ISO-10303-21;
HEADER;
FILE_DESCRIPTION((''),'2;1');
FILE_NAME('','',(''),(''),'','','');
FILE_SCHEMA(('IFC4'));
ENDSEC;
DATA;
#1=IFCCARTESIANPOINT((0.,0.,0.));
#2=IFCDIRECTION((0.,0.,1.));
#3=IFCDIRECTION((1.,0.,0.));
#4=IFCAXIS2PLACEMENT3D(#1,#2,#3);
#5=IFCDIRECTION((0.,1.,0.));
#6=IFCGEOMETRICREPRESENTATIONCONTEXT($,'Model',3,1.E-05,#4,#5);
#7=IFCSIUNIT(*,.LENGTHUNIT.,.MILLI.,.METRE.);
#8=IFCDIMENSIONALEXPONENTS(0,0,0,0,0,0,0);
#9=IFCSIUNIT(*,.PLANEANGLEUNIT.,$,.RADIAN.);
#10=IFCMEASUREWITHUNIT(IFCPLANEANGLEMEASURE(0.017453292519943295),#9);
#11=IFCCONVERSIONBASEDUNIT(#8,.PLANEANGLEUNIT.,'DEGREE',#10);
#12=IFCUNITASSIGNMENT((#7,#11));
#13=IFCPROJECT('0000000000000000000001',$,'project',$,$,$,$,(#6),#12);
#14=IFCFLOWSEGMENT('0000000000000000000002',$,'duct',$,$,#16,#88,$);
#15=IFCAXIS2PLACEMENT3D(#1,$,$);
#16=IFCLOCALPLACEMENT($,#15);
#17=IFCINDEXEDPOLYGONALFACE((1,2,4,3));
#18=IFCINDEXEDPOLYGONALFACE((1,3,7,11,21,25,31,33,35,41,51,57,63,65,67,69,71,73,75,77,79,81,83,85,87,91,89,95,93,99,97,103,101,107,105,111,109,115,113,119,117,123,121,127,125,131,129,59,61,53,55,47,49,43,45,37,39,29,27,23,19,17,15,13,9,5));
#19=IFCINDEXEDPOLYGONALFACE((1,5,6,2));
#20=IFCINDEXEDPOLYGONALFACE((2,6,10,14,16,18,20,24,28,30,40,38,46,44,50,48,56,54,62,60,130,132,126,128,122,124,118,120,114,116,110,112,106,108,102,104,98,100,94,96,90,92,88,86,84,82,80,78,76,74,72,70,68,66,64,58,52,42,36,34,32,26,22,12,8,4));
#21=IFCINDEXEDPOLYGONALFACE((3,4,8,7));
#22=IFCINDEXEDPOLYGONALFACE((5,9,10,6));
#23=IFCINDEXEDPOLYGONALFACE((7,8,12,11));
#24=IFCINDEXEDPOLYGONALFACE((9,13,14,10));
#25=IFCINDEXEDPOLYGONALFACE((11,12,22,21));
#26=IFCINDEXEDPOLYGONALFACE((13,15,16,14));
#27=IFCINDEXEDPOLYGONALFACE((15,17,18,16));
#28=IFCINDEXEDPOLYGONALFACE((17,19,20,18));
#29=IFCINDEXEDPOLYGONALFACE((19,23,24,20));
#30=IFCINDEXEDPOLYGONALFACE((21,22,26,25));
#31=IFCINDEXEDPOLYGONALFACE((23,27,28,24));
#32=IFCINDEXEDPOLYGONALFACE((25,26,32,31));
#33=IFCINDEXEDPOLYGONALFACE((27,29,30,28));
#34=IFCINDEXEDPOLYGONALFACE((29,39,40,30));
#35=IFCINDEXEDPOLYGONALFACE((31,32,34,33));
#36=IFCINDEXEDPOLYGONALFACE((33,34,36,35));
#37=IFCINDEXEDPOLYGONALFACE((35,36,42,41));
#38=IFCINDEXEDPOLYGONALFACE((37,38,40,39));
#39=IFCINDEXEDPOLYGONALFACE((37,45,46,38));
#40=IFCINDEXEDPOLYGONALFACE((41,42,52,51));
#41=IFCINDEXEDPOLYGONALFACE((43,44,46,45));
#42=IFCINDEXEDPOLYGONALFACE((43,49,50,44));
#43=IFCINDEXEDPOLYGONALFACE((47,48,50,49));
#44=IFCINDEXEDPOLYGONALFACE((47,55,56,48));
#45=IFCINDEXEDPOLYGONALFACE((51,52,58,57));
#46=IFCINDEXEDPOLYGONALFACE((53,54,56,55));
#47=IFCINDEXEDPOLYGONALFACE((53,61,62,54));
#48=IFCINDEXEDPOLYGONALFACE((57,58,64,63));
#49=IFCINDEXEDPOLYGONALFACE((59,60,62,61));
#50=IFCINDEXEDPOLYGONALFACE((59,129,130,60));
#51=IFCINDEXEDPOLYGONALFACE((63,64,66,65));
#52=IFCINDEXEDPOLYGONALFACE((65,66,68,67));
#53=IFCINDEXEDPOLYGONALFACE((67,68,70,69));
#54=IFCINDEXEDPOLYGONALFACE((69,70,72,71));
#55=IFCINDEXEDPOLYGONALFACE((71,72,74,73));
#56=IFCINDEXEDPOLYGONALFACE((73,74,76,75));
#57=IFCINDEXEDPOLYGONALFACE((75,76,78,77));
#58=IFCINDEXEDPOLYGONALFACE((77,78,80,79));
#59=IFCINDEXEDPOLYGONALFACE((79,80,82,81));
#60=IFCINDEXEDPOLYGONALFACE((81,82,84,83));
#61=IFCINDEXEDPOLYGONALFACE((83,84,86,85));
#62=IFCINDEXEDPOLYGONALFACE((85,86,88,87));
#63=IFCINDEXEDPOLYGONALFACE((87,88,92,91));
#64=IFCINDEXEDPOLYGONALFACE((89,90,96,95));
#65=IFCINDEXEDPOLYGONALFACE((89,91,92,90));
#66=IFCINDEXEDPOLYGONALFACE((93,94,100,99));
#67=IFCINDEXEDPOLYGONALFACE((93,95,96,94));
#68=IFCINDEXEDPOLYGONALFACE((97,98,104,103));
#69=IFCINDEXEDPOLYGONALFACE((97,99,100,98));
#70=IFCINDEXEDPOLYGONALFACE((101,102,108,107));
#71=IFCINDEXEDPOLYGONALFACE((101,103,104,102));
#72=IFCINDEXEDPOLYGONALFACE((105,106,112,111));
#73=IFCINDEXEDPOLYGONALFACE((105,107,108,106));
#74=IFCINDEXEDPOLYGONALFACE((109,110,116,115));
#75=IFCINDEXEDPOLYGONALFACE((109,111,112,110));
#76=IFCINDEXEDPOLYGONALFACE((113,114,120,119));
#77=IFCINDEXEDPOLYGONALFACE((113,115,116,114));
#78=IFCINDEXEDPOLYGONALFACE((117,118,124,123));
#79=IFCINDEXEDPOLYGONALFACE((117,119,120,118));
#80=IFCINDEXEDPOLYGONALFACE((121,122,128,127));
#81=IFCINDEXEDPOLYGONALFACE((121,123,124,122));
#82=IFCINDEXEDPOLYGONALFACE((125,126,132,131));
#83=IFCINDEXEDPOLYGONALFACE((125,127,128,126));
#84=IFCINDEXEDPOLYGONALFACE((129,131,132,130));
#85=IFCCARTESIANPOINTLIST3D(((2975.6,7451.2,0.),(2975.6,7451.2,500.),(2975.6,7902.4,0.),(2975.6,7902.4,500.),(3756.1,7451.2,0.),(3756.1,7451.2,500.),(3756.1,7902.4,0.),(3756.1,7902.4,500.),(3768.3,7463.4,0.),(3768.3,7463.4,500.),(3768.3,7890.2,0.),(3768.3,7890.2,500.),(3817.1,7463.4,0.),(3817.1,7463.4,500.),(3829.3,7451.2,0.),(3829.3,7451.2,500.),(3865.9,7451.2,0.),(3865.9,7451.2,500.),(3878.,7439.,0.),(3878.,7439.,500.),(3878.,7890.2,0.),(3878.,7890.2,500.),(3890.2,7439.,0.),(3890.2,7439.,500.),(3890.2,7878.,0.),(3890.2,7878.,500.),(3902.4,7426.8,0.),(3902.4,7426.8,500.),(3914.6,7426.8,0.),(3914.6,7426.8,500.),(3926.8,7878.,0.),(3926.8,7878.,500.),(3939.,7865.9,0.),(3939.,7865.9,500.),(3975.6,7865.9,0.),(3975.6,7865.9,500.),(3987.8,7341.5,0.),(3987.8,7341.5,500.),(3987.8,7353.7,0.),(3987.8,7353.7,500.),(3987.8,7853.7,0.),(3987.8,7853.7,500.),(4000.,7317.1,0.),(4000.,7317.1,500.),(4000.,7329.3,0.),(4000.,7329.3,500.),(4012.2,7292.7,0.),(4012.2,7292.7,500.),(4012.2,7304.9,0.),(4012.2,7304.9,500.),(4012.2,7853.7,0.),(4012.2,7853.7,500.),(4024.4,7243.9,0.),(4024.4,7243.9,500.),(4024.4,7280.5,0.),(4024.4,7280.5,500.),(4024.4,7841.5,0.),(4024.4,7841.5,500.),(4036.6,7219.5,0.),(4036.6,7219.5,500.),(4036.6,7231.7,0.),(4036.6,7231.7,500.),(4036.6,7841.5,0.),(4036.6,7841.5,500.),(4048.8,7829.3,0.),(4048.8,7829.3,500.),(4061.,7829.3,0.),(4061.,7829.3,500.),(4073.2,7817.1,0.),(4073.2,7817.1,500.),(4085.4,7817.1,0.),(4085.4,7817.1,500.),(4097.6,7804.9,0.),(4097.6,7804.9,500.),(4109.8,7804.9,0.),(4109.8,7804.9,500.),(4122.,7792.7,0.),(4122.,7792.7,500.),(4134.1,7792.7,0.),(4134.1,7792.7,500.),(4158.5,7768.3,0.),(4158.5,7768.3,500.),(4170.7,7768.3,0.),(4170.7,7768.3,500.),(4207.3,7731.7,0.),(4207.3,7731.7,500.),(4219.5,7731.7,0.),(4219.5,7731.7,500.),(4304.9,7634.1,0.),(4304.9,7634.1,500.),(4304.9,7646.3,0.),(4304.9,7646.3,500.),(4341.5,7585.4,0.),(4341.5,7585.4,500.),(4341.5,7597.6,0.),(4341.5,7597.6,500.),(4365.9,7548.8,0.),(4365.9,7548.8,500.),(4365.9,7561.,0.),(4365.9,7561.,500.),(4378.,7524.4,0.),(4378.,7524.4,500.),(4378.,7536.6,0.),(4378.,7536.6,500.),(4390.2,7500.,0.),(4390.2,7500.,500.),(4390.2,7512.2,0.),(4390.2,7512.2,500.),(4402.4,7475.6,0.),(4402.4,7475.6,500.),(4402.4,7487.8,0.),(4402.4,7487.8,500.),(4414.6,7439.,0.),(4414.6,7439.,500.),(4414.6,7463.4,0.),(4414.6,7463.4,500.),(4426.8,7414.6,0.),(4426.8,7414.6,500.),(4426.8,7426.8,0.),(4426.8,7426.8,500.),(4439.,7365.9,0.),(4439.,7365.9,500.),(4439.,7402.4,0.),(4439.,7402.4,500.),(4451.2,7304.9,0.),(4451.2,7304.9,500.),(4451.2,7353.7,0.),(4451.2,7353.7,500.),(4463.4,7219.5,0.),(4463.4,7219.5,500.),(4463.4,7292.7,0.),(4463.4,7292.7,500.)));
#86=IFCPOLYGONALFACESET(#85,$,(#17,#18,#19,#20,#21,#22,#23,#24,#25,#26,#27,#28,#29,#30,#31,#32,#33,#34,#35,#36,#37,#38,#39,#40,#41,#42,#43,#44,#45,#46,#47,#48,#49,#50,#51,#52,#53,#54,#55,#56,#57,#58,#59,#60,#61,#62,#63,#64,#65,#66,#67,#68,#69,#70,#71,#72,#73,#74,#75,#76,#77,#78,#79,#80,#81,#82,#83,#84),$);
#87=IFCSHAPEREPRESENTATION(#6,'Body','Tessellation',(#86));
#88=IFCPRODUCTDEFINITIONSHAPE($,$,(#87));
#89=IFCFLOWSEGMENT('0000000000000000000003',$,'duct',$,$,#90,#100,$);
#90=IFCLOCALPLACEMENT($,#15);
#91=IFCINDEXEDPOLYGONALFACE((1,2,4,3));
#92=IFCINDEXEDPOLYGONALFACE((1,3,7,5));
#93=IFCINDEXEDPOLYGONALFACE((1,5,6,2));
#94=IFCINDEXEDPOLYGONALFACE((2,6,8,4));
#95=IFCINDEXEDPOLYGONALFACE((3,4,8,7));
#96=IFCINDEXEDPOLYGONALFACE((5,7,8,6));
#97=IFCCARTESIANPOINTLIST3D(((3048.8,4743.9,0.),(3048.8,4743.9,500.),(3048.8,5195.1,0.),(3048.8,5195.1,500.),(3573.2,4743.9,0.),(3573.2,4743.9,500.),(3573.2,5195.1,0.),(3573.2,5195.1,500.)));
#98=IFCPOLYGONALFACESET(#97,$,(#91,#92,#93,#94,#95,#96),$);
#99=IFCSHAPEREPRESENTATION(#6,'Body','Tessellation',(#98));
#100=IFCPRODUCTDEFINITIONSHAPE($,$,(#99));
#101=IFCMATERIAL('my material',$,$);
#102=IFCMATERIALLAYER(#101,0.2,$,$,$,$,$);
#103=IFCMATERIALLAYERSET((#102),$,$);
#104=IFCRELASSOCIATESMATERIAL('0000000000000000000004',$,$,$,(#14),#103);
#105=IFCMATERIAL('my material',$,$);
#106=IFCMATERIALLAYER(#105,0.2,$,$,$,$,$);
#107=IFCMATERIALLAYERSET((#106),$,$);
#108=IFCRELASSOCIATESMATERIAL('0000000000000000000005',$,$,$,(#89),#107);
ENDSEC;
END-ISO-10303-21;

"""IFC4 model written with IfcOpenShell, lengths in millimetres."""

from ifc_helpers import new_model, entity, si_unit, converted_unit, direction, origin_with_axes, place, context, project, polyline, outline, extrude, material, layer, layer_set, layer_usage, element, save


model = new_model("IFC4")

# Units and contexts
model_context = context("Model", 3, precision=1e-05, world=origin_with_axes(), true_north=direction((0.0, 1.0, 0.0)))
ifc_project = project(units=[si_unit("LENGTHUNIT", "METRE", prefix="MILLI"), converted_unit("PLANEANGLEUNIT", "DEGREE", entity("IfcPlaneAngleMeasure", 0.017453292519943295), si_unit("PLANEANGLEUNIT", "RADIAN"), dimensions=[0, 0, 0, 0, 0, 0, 0])], contexts=[model_context])

# Flow segments
ifc_material_1 = material(Name="my material")
ifc_layer_1 = layer(ifc_material_1, 0.2)
ifc_layer_set_1 = layer_set([ifc_layer_1])
ifc_layer_usage_1 = layer_usage(ifc_layer_set_1, "AXIS2", "POSITIVE", -0.1)
flow_segment_1_placement = place(None, origin_with_axes())
element("IfcFlowSegment", 1, at=flow_segment_1_placement, material=ifc_layer_usage_1, Name="duct", context=model_context, shape_type="SweptSolid", body=[
    extrude(outline(polyline([(2975.6, 7451.2), (3756.1, 7451.2), (3768.3, 7463.4), (3817.1, 7463.4), (3829.3, 7451.2), (3865.9, 7451.2), (3878.0, 7439.0), (3890.2, 7439.0), (3902.4, 7426.8), (3914.6, 7426.8), (3987.8, 7353.7), (3987.8, 7341.5), (4000.0, 7329.3), (4000.0, 7317.1), (4012.2, 7304.9), (4012.2, 7292.7), (4024.4, 7280.5), (4024.4, 7243.9), (4036.6, 7231.7), (4036.6, 7219.5), (4463.4, 7219.5), (4463.4, 7292.7), (4451.2, 7304.9), (4451.2, 7353.7), (4439.0, 7365.9), (4439.0, 7402.4), (4426.8, 7414.6), (4426.8, 7426.8), (4414.6, 7439.0), (4414.6, 7463.4), (4402.4, 7475.6), (4402.4, 7487.8), (4390.2, 7500.0), (4390.2, 7512.2), (4378.0, 7524.4), (4378.0, 7536.6), (4365.9, 7548.8), (4365.9, 7561.0), (4341.5, 7585.4), (4341.5, 7597.6), (4304.9, 7634.1), (4304.9, 7646.3), (4219.5, 7731.7), (4207.3, 7731.7), (4170.7, 7768.3), (4158.5, 7768.3), (4134.1, 7792.7), (4122.0, 7792.7), (4109.8, 7804.9), (4097.6, 7804.9), (4085.4, 7817.1), (4073.2, 7817.1), (4061.0, 7829.3), (4048.8, 7829.3), (4036.6, 7841.5), (4024.4, 7841.5), (4012.2, 7853.7), (3987.8, 7853.7), (3975.6, 7865.9), (3939.0, 7865.9), (3926.8, 7878.0), (3890.2, 7878.0), (3878.0, 7890.2), (3768.3, 7890.2), (3756.1, 7902.4), (2975.6, 7902.4), (2975.6, 7451.2)])), origin_with_axes(), (0.0, 0.0, 1.0), 500.0),
])
ifc_material_2 = material(Name="my material")
ifc_layer_2 = layer(ifc_material_2, 0.2)
ifc_layer_set_2 = layer_set([ifc_layer_2])
ifc_layer_usage_2 = layer_usage(ifc_layer_set_2, "AXIS2", "POSITIVE", -0.1)
flow_segment_2_placement = place(None, origin_with_axes())
element("IfcFlowSegment", 2, at=flow_segment_2_placement, material=ifc_layer_usage_2, Name="duct", context=model_context, shape_type="SweptSolid", body=[
    extrude(outline(polyline([(3048.8, 4743.9), (3573.2, 4743.9), (3573.2, 5195.1), (3048.8, 5195.1), (3048.8, 4743.9)])), origin_with_axes(), (0.0, 0.0, 1.0), 500.0),
])

save(model, "model.ifc")
